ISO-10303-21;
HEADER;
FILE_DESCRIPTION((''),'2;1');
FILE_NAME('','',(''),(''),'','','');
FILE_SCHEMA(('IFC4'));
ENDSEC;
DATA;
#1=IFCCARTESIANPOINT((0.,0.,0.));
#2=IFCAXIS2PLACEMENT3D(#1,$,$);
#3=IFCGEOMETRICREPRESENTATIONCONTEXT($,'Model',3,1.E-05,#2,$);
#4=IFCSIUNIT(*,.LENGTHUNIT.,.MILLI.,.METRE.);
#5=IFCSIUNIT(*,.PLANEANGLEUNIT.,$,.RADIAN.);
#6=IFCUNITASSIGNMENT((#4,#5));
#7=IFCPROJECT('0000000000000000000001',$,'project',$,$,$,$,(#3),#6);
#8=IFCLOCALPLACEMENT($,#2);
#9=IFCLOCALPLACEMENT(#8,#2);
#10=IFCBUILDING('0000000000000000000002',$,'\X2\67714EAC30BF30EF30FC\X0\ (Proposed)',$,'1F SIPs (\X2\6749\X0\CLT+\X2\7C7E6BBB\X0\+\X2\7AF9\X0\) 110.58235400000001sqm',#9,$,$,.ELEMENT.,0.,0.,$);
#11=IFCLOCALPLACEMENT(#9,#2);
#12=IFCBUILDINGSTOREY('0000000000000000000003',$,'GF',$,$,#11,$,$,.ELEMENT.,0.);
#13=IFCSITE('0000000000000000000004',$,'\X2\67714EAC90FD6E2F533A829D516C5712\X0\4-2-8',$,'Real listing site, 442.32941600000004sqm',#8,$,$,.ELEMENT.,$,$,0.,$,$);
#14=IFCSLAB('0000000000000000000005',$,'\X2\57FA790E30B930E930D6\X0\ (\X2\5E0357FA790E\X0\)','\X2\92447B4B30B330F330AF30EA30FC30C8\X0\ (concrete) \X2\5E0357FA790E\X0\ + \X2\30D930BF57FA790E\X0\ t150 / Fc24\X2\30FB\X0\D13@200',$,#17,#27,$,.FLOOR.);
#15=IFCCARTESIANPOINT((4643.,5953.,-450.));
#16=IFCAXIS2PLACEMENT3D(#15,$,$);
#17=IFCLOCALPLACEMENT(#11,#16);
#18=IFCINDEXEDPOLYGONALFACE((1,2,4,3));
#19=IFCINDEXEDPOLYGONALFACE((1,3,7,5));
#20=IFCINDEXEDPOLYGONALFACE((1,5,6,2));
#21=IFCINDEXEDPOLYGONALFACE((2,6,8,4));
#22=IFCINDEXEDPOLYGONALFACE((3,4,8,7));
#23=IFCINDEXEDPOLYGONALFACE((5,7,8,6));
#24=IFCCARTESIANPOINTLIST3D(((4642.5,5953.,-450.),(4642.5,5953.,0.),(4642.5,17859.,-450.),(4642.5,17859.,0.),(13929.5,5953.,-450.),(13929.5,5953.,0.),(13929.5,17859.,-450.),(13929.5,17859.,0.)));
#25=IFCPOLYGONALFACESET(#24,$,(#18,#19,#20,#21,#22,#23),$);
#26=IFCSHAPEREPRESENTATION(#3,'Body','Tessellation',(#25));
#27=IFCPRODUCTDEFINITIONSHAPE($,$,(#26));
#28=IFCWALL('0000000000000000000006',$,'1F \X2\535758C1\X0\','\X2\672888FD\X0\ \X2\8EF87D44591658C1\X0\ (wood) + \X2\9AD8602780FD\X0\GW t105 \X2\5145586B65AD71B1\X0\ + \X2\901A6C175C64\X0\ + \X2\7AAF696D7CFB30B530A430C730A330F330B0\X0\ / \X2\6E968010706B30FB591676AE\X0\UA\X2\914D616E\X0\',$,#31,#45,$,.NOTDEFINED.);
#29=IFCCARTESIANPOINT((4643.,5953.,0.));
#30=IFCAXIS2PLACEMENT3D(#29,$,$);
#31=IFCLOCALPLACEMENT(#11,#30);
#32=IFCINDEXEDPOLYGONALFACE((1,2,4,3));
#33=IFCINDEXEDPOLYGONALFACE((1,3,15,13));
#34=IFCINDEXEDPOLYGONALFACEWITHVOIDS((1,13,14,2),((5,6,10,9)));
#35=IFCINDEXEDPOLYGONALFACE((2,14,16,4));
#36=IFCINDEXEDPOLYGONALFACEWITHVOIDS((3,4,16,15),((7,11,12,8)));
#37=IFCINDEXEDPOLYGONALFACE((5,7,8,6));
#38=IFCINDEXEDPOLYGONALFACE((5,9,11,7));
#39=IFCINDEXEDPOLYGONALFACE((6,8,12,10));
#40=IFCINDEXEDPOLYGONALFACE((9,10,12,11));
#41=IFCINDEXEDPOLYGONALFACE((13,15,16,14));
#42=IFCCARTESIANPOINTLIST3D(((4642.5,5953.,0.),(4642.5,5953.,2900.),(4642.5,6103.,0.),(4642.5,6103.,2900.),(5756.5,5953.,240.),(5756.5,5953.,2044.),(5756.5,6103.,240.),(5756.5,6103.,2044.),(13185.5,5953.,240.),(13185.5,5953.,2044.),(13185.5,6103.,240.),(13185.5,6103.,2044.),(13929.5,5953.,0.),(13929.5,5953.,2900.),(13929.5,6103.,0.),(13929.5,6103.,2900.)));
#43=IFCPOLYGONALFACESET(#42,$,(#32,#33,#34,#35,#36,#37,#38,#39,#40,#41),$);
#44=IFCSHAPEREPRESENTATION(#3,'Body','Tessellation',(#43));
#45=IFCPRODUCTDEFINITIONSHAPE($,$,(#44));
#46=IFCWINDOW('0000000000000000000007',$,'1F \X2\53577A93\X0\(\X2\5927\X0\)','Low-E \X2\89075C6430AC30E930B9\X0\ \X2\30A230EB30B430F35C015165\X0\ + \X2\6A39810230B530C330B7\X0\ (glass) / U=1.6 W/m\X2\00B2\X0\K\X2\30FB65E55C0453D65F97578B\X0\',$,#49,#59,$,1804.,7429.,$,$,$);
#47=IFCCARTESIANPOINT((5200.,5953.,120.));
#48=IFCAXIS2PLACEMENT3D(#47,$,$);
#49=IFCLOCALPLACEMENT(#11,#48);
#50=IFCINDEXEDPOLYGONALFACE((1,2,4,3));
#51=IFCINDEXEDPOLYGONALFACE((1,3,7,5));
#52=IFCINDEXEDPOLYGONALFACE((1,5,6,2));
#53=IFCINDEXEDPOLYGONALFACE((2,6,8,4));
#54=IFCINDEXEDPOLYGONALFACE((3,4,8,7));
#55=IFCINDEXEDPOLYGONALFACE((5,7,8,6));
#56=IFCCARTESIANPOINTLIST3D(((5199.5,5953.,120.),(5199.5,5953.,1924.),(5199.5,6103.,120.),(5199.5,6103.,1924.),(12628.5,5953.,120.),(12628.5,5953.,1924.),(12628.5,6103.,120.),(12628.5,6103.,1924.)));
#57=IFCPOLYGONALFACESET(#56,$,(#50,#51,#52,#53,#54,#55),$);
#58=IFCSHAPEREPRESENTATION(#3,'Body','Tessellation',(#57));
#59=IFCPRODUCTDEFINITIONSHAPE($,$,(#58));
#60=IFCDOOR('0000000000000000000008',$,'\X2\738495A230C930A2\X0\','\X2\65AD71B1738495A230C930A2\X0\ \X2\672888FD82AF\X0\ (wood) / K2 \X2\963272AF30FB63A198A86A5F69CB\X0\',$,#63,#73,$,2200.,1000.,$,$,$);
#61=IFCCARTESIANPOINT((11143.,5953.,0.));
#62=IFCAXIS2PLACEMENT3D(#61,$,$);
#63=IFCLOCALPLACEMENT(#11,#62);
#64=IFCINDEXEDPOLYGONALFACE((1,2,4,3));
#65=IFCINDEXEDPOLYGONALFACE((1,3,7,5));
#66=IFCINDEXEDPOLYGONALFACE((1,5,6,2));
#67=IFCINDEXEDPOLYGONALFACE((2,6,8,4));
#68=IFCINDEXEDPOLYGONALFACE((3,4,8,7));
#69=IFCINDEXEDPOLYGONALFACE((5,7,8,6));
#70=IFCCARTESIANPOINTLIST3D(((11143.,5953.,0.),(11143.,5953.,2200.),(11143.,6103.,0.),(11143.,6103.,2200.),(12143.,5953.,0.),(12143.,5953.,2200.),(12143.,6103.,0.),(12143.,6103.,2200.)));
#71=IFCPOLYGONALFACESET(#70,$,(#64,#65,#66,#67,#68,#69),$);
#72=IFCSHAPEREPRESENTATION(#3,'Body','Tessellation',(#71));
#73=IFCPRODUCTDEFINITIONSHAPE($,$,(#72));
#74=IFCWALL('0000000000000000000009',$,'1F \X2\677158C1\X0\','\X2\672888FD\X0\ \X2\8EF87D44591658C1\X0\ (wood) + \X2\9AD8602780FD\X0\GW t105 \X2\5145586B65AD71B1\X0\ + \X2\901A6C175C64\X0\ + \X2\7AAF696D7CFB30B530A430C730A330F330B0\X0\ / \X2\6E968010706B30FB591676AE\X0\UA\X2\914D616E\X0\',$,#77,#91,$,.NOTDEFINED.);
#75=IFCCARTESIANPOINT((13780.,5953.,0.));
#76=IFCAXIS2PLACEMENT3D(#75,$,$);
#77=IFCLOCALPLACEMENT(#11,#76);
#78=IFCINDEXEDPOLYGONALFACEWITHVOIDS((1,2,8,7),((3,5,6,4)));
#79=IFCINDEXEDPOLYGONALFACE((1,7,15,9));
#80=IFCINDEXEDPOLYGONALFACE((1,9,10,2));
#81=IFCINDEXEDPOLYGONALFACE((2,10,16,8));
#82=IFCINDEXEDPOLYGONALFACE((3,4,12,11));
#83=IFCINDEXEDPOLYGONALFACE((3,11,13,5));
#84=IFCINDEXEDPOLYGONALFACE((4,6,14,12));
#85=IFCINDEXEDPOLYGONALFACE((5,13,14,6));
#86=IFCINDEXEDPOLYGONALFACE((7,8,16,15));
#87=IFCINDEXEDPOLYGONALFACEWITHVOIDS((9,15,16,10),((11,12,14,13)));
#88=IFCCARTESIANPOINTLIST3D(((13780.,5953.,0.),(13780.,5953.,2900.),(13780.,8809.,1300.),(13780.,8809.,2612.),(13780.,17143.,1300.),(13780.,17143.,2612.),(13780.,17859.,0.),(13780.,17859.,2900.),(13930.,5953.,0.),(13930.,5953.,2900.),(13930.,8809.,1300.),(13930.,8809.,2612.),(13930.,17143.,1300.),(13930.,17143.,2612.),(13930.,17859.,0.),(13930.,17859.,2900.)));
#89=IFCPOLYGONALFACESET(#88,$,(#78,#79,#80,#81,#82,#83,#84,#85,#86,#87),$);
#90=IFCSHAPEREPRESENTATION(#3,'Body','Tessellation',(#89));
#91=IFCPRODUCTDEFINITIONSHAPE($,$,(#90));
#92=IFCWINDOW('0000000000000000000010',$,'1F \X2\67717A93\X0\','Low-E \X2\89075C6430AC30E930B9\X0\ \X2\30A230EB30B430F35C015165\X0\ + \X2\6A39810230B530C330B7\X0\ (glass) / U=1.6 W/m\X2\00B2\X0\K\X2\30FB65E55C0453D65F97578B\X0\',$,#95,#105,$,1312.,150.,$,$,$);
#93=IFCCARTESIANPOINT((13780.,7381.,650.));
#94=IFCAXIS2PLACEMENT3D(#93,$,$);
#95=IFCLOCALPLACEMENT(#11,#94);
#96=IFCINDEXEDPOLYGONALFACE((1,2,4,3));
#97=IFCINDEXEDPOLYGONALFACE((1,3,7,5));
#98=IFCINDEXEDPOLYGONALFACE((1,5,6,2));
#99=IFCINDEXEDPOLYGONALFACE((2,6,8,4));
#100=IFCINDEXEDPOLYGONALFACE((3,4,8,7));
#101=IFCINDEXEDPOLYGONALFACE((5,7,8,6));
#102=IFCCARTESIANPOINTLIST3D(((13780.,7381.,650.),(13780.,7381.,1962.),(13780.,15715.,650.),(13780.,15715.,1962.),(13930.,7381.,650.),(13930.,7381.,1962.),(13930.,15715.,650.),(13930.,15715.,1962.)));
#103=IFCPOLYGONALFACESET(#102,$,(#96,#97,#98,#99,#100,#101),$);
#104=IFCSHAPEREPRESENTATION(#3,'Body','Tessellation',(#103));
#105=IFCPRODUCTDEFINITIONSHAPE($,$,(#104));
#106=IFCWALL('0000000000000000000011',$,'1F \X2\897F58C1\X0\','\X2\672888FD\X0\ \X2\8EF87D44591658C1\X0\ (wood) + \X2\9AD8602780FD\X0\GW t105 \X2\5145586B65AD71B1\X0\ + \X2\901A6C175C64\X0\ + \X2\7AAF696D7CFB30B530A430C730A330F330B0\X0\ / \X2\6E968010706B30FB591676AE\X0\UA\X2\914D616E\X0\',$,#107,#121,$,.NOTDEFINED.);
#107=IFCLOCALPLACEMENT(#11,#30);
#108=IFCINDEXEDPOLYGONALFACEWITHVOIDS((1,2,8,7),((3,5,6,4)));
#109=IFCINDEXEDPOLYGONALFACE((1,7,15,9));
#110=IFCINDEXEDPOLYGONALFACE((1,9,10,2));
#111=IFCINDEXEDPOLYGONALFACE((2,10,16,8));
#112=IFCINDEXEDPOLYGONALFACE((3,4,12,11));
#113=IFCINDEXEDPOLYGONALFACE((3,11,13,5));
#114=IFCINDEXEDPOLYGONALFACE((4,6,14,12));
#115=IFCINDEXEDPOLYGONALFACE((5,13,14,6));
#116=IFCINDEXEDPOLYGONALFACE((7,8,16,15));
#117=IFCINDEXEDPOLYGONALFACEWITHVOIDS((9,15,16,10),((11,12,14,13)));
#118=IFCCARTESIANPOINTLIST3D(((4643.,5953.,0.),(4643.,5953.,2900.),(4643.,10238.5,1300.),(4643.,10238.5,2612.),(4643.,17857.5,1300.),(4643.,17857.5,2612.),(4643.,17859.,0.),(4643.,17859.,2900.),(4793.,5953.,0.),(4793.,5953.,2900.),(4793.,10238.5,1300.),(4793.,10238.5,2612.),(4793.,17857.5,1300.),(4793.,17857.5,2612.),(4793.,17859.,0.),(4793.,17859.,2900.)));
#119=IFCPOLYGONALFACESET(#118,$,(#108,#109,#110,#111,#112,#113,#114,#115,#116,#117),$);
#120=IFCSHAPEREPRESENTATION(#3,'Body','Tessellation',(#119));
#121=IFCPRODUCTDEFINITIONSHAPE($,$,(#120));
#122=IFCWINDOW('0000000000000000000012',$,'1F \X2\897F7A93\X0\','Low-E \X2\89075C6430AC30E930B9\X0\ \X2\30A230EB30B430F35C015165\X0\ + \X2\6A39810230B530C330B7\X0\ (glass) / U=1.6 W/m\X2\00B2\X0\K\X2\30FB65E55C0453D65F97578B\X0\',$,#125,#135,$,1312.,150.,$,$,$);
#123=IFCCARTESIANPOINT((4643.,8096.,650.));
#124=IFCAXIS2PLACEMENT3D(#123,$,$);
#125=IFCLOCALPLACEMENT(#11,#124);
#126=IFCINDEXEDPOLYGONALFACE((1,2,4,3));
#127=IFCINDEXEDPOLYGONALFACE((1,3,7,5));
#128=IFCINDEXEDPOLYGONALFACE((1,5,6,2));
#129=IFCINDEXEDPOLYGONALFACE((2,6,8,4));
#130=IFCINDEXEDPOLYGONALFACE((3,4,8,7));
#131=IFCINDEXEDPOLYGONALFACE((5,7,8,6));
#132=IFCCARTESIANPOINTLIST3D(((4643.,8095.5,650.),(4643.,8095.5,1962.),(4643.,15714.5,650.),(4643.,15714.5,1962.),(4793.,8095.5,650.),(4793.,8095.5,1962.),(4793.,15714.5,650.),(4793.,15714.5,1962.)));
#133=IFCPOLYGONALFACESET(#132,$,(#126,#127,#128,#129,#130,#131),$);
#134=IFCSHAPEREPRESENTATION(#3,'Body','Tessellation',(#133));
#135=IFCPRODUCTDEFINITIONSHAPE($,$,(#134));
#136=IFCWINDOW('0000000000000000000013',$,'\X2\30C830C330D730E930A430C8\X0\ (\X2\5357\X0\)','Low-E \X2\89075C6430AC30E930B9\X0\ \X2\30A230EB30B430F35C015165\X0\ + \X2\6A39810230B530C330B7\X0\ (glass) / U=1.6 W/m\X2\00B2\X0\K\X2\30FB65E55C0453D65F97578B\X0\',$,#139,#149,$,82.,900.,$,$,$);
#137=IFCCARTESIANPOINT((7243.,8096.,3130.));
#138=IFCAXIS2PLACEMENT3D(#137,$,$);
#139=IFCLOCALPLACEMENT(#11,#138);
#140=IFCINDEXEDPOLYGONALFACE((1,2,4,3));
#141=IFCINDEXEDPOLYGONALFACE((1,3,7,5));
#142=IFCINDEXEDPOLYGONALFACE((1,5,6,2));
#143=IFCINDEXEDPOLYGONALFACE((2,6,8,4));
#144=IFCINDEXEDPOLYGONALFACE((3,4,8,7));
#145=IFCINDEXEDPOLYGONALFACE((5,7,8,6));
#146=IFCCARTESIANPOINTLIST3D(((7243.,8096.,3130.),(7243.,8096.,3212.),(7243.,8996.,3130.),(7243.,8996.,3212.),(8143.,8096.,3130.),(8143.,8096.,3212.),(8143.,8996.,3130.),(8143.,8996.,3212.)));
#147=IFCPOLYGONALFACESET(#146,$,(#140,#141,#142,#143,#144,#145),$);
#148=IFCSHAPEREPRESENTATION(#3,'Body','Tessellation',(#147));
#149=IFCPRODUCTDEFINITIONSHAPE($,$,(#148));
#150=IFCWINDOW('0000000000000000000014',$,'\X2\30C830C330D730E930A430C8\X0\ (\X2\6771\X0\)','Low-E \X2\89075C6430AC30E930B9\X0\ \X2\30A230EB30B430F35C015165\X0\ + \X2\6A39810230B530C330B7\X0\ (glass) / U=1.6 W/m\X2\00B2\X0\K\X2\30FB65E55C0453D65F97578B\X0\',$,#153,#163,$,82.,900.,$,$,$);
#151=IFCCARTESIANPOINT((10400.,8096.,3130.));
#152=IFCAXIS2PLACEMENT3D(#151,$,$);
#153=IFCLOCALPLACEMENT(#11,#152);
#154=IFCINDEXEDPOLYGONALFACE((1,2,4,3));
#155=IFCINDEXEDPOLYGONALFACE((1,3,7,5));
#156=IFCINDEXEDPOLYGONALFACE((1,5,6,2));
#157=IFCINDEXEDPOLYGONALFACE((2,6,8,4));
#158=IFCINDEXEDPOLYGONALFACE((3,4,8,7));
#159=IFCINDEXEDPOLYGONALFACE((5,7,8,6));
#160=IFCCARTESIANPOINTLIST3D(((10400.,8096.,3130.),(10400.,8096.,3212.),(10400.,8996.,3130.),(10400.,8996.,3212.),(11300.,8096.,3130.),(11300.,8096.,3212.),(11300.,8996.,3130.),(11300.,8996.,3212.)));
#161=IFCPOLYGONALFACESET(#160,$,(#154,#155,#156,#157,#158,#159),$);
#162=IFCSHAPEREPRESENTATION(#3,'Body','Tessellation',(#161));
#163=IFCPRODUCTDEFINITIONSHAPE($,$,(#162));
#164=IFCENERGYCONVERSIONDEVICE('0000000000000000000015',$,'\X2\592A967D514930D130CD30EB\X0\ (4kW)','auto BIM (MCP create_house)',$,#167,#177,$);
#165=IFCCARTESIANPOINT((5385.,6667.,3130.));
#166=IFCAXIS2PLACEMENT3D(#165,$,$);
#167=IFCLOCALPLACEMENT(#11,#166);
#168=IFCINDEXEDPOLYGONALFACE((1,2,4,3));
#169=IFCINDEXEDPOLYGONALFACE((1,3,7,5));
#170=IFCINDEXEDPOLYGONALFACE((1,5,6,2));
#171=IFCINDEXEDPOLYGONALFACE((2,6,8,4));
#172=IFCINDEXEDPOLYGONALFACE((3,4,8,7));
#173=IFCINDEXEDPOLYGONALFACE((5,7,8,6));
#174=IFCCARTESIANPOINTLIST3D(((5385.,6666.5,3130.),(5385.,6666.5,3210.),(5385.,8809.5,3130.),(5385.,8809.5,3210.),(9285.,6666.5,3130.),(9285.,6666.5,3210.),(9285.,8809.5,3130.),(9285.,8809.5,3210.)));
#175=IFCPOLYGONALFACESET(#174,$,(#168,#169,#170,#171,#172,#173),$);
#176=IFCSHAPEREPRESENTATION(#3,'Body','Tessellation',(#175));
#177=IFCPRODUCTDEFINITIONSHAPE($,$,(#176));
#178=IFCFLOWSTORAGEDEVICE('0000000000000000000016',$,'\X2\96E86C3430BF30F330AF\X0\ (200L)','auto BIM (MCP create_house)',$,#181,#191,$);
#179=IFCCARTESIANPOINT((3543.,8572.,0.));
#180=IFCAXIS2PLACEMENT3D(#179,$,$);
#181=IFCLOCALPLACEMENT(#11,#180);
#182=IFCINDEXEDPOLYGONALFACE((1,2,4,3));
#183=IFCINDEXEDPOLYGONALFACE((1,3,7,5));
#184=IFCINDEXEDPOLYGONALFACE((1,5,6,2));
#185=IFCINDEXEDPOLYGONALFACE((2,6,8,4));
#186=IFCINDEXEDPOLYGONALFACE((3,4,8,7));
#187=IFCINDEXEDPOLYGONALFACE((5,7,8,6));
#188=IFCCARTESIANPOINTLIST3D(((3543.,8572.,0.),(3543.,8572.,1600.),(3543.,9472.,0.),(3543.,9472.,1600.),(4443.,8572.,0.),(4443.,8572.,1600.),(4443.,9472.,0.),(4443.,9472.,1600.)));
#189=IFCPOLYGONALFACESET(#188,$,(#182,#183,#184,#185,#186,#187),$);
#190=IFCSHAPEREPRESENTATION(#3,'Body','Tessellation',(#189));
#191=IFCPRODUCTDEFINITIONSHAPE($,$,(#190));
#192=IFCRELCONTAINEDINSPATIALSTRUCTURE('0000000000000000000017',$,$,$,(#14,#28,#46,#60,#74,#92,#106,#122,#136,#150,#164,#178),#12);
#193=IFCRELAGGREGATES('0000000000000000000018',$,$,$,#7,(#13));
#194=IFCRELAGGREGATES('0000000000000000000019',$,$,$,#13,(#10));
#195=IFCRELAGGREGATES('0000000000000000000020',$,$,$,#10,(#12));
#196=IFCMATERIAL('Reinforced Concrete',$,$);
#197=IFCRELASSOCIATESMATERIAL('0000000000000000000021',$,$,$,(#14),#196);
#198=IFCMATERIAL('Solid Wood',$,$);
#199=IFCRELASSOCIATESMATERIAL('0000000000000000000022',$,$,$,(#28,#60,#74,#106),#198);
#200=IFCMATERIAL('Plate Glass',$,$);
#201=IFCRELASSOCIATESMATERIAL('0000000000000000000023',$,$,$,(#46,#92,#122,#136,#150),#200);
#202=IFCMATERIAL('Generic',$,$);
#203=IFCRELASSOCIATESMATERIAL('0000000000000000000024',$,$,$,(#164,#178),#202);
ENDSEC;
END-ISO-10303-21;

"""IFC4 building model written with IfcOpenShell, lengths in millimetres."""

from ifc_helpers import new_model, si_unit, frame, frame_2d, origin, place, context, project, spatial, rectangle, extrude, material, element, fill, save


model = new_model("IFC4")

# Units and contexts
model_context = context("Model", 3, precision=1e-05, world=origin())
ifc_project = project(units=[si_unit("LENGTHUNIT", "METRE", prefix="MILLI"), si_unit("PLANEANGLEUNIT", "RADIAN")], contexts=[model_context])

# Site, building, storey
site_placement = place(None, origin())
site = spatial("IfcSite", under=ifc_project, at=site_placement, Name="東京都港区芝公園4-2-8", ObjectType="Real listing site, 442.32941600000004sqm", CompositionType="ELEMENT", RefElevation=0.0)
building_placement = place(site_placement, origin())
building = spatial("IfcBuilding", under=site, at=building_placement, Name="東京タワー (Proposed)", ObjectType="1F SIPs (杉CLT+籾殻+竹) 110.58235400000001sqm", CompositionType="ELEMENT", ElevationOfRefHeight=0.0, ElevationOfTerrain=0.0)
storey_placement = place(building_placement, origin())
storey = spatial("IfcBuildingStorey", under=building, at=storey_placement, Name="GF", CompositionType="ELEMENT", Elevation=0.0)

# Slab
ifc_material_1 = material(Name="Reinforced Concrete")
slab_1_placement = place(storey_placement, frame((4643.0, 5953.0, -450.0)))
element("IfcSlab", 1, at=slab_1_placement, inside=storey, material=ifc_material_1, Name="基礎スラブ (布基礎)", Description="鉄筋コンクリート (concrete) 布基礎 + ベタ基礎 t150 / Fc24・D13@200", PredefinedType="FLOOR", context=model_context, shape_type="SweptSolid", body=[
    extrude(rectangle(XDim=9287.0, YDim=11906.0, at=frame_2d((4643.0, 5953.0))), frame((4643.0, 5953.0, -450.0)), (0.0, 0.0, 1.0), 450.0),
])
ifc_material_2 = material(Name="Solid Wood")

# Wall, openings, window, door
wall_1_placement = place(storey_placement, frame((4643.0, 5953.0, 0.0)))
wall_1 = element("IfcWall", 2, at=wall_1_placement, inside=storey, material=ifc_material_2, Name="1F 南壁", Description="木製 軸組外壁 (wood) + 高性能GW t105 充填断熱 + 通気層 + 窯業系サイディング / 準耐火・外皮UA配慮", PredefinedType="NOTDEFINED", context=model_context, shape_type="SweptSolid", body=[
    extrude(rectangle(XDim=9287.0, YDim=150.0, at=frame_2d((4643.0, 75.0))), frame((4643.0, 5953.0, 0.0)), (0.0, 0.0, 1.0), 2900.0),
])
opening_1_placement = place(storey_placement, frame((5200.0, 5953.0, 120.0)))
opening_1 = element("IfcOpeningElement", 3, at=opening_1_placement, cuts=wall_1, PredefinedType="NOTDEFINED", context=model_context, shape_type="SweptSolid", body=[
    extrude(rectangle(XDim=7429.0, YDim=150.0, at=frame_2d((3714.0, 75.0))), frame((5200.0, 5953.0, 120.0)), (0.0, 0.0, 1.0), 1804.0),
])
opening_2_placement = place(storey_placement, frame((11143.0, 5953.0, 0.0)))
opening_2 = element("IfcOpeningElement", 4, at=opening_2_placement, cuts=wall_1, PredefinedType="NOTDEFINED", context=model_context, shape_type="SweptSolid", body=[
    extrude(rectangle(XDim=1000.0, YDim=150.0, at=frame_2d((500.0, 75.0))), frame((11143.0, 5953.0, 0.0)), (0.0, 0.0, 1.0), 2200.0),
])
ifc_material_3 = material(Name="Plate Glass")
window_1_placement = place(storey_placement, frame((5200.0, 5953.0, 120.0)))
window_1 = element("IfcWindow", 5, at=window_1_placement, inside=storey, material=ifc_material_3, Name="1F 南窓(大)", Description="Low-E 複層ガラス アルゴン封入 + 樹脂サッシ (glass) / U=1.6 W/m²K・日射取得型", OverallHeight=1804.0, OverallWidth=7429.0, context=model_context, shape_type="SweptSolid", body=[
    extrude(rectangle(XDim=7429.0, YDim=150.0, at=frame_2d((3714.0, 75.0))), frame((5200.0, 5953.0, 120.0)), (0.0, 0.0, 1.0), 1804.0),
])
fill(opening_1, window_1)
door_placement = place(storey_placement, frame((11143.0, 5953.0, 0.0)))
door = element("IfcDoor", 6, at=door_placement, inside=storey, material=ifc_material_2, Name="玄関ドア", Description="断熱玄関ドア 木製芯 (wood) / K2 防犯・採風機構", OverallHeight=2200.0, OverallWidth=1000.0, context=model_context, shape_type="SweptSolid", body=[
    extrude(rectangle(XDim=1000.0, YDim=150.0, at=frame_2d((500.0, 75.0))), frame((11143.0, 5953.0, 0.0)), (0.0, 0.0, 1.0), 2200.0),
])
fill(opening_2, door)

# Walls, openings, windows
wall_2_placement = place(storey_placement, frame((13780.0, 5953.0, 0.0)))
wall_2 = element("IfcWall", 7, at=wall_2_placement, inside=storey, material=ifc_material_2, Name="1F 東壁", Description="木製 軸組外壁 (wood) + 高性能GW t105 充填断熱 + 通気層 + 窯業系サイディング / 準耐火・外皮UA配慮", PredefinedType="NOTDEFINED", context=model_context, shape_type="SweptSolid", body=[
    extrude(rectangle(XDim=150.0, YDim=11906.0, at=frame_2d((75.0, 5953.0))), frame((13780.0, 5953.0, 0.0)), (0.0, 0.0, 1.0), 2900.0),
])
opening_3_placement = place(storey_placement, frame((13780.0, 7381.0, 650.0)))
opening_3 = element("IfcOpeningElement", 8, at=opening_3_placement, cuts=wall_2, PredefinedType="NOTDEFINED", context=model_context, shape_type="SweptSolid", body=[
    extrude(rectangle(XDim=150.0, YDim=8334.0, at=frame_2d((75.0, 4167.0))), frame((13780.0, 7381.0, 650.0)), (0.0, 0.0, 1.0), 1312.0),
])
window_2_placement = place(storey_placement, frame((13780.0, 7381.0, 650.0)))
window_2 = element("IfcWindow", 9, at=window_2_placement, inside=storey, material=ifc_material_3, Name="1F 東窓", Description="Low-E 複層ガラス アルゴン封入 + 樹脂サッシ (glass) / U=1.6 W/m²K・日射取得型", OverallHeight=1312.0, OverallWidth=150.0, context=model_context, shape_type="SweptSolid", body=[
    extrude(rectangle(XDim=150.0, YDim=8334.0, at=frame_2d((75.0, 4167.0))), frame((13780.0, 7381.0, 650.0)), (0.0, 0.0, 1.0), 1312.0),
])
fill(opening_3, window_2)
wall_3_placement = place(storey_placement, frame((4643.0, 5953.0, 0.0)))
wall_3 = element("IfcWall", 10, at=wall_3_placement, inside=storey, material=ifc_material_2, Name="1F 西壁", Description="木製 軸組外壁 (wood) + 高性能GW t105 充填断熱 + 通気層 + 窯業系サイディング / 準耐火・外皮UA配慮", PredefinedType="NOTDEFINED", context=model_context, shape_type="SweptSolid", body=[
    extrude(rectangle(XDim=150.0, YDim=11906.0, at=frame_2d((75.0, 5953.0))), frame((4643.0, 5953.0, 0.0)), (0.0, 0.0, 1.0), 2900.0),
])
opening_4_placement = place(storey_placement, frame((4643.0, 8096.0, 650.0)))
opening_4 = element("IfcOpeningElement", 11, at=opening_4_placement, cuts=wall_3, PredefinedType="NOTDEFINED", context=model_context, shape_type="SweptSolid", body=[
    extrude(rectangle(XDim=150.0, YDim=7619.0, at=frame_2d((75.0, 3809.0))), frame((4643.0, 8096.0, 650.0)), (0.0, 0.0, 1.0), 1312.0),
])
window_3_placement = place(storey_placement, frame((4643.0, 8096.0, 650.0)))
window_3 = element("IfcWindow", 12, at=window_3_placement, inside=storey, material=ifc_material_3, Name="1F 西窓", Description="Low-E 複層ガラス アルゴン封入 + 樹脂サッシ (glass) / U=1.6 W/m²K・日射取得型", OverallHeight=1312.0, OverallWidth=150.0, context=model_context, shape_type="SweptSolid", body=[
    extrude(rectangle(XDim=150.0, YDim=7619.0, at=frame_2d((75.0, 3809.0))), frame((4643.0, 8096.0, 650.0)), (0.0, 0.0, 1.0), 1312.0),
])
fill(opening_4, window_3)

# Windows
window_4_placement = place(storey_placement, frame((7243.0, 8096.0, 3130.0)))
element("IfcWindow", 13, at=window_4_placement, inside=storey, material=ifc_material_3, Name="トップライト (南)", Description="Low-E 複層ガラス アルゴン封入 + 樹脂サッシ (glass) / U=1.6 W/m²K・日射取得型", OverallHeight=82.0, OverallWidth=900.0, context=model_context, shape_type="SweptSolid", body=[
    extrude(rectangle(XDim=900.0, YDim=900.0, at=frame_2d((450.0, 450.0))), frame((7243.0, 8096.0, 3130.0)), (0.0, 0.0, 1.0), 82.0),
])
window_5_placement = place(storey_placement, frame((10400.0, 8096.0, 3130.0)))
element("IfcWindow", 14, at=window_5_placement, inside=storey, material=ifc_material_3, Name="トップライト (東)", Description="Low-E 複層ガラス アルゴン封入 + 樹脂サッシ (glass) / U=1.6 W/m²K・日射取得型", OverallHeight=82.0, OverallWidth=900.0, context=model_context, shape_type="SweptSolid", body=[
    extrude(rectangle(XDim=900.0, YDim=900.0, at=frame_2d((450.0, 450.0))), frame((10400.0, 8096.0, 3130.0)), (0.0, 0.0, 1.0), 82.0),
])

# Shared definitions
ifc_material_4 = material(Name="Generic")

# Energy conversion device
energy_conversion_device_placement = place(storey_placement, frame((5385.0, 6667.0, 3130.0)))
element("IfcEnergyConversionDevice", 15, at=energy_conversion_device_placement, inside=storey, material=ifc_material_4, Name="太陽光パネル (4kW)", Description="auto BIM (MCP create_house)", context=model_context, shape_type="SweptSolid", body=[
    extrude(rectangle(XDim=3900.0, YDim=2143.0, at=frame_2d((1950.0, 1071.0))), frame((5385.0, 6667.0, 3130.0)), (0.0, 0.0, 1.0), 80.0),
])

# Flow storage device
flow_storage_device_placement = place(storey_placement, frame((3543.0, 8572.0, 0.0)))
element("IfcFlowStorageDevice", 16, at=flow_storage_device_placement, inside=storey, material=ifc_material_4, Name="雨水タンク (200L)", Description="auto BIM (MCP create_house)", context=model_context, shape_type="SweptSolid", body=[
    extrude(rectangle(XDim=900.0, YDim=900.0, at=frame_2d((450.0, 450.0))), frame((3543.0, 8572.0, 0.0)), (0.0, 0.0, 1.0), 1600.0),
])

save(model, "model.ifc")
